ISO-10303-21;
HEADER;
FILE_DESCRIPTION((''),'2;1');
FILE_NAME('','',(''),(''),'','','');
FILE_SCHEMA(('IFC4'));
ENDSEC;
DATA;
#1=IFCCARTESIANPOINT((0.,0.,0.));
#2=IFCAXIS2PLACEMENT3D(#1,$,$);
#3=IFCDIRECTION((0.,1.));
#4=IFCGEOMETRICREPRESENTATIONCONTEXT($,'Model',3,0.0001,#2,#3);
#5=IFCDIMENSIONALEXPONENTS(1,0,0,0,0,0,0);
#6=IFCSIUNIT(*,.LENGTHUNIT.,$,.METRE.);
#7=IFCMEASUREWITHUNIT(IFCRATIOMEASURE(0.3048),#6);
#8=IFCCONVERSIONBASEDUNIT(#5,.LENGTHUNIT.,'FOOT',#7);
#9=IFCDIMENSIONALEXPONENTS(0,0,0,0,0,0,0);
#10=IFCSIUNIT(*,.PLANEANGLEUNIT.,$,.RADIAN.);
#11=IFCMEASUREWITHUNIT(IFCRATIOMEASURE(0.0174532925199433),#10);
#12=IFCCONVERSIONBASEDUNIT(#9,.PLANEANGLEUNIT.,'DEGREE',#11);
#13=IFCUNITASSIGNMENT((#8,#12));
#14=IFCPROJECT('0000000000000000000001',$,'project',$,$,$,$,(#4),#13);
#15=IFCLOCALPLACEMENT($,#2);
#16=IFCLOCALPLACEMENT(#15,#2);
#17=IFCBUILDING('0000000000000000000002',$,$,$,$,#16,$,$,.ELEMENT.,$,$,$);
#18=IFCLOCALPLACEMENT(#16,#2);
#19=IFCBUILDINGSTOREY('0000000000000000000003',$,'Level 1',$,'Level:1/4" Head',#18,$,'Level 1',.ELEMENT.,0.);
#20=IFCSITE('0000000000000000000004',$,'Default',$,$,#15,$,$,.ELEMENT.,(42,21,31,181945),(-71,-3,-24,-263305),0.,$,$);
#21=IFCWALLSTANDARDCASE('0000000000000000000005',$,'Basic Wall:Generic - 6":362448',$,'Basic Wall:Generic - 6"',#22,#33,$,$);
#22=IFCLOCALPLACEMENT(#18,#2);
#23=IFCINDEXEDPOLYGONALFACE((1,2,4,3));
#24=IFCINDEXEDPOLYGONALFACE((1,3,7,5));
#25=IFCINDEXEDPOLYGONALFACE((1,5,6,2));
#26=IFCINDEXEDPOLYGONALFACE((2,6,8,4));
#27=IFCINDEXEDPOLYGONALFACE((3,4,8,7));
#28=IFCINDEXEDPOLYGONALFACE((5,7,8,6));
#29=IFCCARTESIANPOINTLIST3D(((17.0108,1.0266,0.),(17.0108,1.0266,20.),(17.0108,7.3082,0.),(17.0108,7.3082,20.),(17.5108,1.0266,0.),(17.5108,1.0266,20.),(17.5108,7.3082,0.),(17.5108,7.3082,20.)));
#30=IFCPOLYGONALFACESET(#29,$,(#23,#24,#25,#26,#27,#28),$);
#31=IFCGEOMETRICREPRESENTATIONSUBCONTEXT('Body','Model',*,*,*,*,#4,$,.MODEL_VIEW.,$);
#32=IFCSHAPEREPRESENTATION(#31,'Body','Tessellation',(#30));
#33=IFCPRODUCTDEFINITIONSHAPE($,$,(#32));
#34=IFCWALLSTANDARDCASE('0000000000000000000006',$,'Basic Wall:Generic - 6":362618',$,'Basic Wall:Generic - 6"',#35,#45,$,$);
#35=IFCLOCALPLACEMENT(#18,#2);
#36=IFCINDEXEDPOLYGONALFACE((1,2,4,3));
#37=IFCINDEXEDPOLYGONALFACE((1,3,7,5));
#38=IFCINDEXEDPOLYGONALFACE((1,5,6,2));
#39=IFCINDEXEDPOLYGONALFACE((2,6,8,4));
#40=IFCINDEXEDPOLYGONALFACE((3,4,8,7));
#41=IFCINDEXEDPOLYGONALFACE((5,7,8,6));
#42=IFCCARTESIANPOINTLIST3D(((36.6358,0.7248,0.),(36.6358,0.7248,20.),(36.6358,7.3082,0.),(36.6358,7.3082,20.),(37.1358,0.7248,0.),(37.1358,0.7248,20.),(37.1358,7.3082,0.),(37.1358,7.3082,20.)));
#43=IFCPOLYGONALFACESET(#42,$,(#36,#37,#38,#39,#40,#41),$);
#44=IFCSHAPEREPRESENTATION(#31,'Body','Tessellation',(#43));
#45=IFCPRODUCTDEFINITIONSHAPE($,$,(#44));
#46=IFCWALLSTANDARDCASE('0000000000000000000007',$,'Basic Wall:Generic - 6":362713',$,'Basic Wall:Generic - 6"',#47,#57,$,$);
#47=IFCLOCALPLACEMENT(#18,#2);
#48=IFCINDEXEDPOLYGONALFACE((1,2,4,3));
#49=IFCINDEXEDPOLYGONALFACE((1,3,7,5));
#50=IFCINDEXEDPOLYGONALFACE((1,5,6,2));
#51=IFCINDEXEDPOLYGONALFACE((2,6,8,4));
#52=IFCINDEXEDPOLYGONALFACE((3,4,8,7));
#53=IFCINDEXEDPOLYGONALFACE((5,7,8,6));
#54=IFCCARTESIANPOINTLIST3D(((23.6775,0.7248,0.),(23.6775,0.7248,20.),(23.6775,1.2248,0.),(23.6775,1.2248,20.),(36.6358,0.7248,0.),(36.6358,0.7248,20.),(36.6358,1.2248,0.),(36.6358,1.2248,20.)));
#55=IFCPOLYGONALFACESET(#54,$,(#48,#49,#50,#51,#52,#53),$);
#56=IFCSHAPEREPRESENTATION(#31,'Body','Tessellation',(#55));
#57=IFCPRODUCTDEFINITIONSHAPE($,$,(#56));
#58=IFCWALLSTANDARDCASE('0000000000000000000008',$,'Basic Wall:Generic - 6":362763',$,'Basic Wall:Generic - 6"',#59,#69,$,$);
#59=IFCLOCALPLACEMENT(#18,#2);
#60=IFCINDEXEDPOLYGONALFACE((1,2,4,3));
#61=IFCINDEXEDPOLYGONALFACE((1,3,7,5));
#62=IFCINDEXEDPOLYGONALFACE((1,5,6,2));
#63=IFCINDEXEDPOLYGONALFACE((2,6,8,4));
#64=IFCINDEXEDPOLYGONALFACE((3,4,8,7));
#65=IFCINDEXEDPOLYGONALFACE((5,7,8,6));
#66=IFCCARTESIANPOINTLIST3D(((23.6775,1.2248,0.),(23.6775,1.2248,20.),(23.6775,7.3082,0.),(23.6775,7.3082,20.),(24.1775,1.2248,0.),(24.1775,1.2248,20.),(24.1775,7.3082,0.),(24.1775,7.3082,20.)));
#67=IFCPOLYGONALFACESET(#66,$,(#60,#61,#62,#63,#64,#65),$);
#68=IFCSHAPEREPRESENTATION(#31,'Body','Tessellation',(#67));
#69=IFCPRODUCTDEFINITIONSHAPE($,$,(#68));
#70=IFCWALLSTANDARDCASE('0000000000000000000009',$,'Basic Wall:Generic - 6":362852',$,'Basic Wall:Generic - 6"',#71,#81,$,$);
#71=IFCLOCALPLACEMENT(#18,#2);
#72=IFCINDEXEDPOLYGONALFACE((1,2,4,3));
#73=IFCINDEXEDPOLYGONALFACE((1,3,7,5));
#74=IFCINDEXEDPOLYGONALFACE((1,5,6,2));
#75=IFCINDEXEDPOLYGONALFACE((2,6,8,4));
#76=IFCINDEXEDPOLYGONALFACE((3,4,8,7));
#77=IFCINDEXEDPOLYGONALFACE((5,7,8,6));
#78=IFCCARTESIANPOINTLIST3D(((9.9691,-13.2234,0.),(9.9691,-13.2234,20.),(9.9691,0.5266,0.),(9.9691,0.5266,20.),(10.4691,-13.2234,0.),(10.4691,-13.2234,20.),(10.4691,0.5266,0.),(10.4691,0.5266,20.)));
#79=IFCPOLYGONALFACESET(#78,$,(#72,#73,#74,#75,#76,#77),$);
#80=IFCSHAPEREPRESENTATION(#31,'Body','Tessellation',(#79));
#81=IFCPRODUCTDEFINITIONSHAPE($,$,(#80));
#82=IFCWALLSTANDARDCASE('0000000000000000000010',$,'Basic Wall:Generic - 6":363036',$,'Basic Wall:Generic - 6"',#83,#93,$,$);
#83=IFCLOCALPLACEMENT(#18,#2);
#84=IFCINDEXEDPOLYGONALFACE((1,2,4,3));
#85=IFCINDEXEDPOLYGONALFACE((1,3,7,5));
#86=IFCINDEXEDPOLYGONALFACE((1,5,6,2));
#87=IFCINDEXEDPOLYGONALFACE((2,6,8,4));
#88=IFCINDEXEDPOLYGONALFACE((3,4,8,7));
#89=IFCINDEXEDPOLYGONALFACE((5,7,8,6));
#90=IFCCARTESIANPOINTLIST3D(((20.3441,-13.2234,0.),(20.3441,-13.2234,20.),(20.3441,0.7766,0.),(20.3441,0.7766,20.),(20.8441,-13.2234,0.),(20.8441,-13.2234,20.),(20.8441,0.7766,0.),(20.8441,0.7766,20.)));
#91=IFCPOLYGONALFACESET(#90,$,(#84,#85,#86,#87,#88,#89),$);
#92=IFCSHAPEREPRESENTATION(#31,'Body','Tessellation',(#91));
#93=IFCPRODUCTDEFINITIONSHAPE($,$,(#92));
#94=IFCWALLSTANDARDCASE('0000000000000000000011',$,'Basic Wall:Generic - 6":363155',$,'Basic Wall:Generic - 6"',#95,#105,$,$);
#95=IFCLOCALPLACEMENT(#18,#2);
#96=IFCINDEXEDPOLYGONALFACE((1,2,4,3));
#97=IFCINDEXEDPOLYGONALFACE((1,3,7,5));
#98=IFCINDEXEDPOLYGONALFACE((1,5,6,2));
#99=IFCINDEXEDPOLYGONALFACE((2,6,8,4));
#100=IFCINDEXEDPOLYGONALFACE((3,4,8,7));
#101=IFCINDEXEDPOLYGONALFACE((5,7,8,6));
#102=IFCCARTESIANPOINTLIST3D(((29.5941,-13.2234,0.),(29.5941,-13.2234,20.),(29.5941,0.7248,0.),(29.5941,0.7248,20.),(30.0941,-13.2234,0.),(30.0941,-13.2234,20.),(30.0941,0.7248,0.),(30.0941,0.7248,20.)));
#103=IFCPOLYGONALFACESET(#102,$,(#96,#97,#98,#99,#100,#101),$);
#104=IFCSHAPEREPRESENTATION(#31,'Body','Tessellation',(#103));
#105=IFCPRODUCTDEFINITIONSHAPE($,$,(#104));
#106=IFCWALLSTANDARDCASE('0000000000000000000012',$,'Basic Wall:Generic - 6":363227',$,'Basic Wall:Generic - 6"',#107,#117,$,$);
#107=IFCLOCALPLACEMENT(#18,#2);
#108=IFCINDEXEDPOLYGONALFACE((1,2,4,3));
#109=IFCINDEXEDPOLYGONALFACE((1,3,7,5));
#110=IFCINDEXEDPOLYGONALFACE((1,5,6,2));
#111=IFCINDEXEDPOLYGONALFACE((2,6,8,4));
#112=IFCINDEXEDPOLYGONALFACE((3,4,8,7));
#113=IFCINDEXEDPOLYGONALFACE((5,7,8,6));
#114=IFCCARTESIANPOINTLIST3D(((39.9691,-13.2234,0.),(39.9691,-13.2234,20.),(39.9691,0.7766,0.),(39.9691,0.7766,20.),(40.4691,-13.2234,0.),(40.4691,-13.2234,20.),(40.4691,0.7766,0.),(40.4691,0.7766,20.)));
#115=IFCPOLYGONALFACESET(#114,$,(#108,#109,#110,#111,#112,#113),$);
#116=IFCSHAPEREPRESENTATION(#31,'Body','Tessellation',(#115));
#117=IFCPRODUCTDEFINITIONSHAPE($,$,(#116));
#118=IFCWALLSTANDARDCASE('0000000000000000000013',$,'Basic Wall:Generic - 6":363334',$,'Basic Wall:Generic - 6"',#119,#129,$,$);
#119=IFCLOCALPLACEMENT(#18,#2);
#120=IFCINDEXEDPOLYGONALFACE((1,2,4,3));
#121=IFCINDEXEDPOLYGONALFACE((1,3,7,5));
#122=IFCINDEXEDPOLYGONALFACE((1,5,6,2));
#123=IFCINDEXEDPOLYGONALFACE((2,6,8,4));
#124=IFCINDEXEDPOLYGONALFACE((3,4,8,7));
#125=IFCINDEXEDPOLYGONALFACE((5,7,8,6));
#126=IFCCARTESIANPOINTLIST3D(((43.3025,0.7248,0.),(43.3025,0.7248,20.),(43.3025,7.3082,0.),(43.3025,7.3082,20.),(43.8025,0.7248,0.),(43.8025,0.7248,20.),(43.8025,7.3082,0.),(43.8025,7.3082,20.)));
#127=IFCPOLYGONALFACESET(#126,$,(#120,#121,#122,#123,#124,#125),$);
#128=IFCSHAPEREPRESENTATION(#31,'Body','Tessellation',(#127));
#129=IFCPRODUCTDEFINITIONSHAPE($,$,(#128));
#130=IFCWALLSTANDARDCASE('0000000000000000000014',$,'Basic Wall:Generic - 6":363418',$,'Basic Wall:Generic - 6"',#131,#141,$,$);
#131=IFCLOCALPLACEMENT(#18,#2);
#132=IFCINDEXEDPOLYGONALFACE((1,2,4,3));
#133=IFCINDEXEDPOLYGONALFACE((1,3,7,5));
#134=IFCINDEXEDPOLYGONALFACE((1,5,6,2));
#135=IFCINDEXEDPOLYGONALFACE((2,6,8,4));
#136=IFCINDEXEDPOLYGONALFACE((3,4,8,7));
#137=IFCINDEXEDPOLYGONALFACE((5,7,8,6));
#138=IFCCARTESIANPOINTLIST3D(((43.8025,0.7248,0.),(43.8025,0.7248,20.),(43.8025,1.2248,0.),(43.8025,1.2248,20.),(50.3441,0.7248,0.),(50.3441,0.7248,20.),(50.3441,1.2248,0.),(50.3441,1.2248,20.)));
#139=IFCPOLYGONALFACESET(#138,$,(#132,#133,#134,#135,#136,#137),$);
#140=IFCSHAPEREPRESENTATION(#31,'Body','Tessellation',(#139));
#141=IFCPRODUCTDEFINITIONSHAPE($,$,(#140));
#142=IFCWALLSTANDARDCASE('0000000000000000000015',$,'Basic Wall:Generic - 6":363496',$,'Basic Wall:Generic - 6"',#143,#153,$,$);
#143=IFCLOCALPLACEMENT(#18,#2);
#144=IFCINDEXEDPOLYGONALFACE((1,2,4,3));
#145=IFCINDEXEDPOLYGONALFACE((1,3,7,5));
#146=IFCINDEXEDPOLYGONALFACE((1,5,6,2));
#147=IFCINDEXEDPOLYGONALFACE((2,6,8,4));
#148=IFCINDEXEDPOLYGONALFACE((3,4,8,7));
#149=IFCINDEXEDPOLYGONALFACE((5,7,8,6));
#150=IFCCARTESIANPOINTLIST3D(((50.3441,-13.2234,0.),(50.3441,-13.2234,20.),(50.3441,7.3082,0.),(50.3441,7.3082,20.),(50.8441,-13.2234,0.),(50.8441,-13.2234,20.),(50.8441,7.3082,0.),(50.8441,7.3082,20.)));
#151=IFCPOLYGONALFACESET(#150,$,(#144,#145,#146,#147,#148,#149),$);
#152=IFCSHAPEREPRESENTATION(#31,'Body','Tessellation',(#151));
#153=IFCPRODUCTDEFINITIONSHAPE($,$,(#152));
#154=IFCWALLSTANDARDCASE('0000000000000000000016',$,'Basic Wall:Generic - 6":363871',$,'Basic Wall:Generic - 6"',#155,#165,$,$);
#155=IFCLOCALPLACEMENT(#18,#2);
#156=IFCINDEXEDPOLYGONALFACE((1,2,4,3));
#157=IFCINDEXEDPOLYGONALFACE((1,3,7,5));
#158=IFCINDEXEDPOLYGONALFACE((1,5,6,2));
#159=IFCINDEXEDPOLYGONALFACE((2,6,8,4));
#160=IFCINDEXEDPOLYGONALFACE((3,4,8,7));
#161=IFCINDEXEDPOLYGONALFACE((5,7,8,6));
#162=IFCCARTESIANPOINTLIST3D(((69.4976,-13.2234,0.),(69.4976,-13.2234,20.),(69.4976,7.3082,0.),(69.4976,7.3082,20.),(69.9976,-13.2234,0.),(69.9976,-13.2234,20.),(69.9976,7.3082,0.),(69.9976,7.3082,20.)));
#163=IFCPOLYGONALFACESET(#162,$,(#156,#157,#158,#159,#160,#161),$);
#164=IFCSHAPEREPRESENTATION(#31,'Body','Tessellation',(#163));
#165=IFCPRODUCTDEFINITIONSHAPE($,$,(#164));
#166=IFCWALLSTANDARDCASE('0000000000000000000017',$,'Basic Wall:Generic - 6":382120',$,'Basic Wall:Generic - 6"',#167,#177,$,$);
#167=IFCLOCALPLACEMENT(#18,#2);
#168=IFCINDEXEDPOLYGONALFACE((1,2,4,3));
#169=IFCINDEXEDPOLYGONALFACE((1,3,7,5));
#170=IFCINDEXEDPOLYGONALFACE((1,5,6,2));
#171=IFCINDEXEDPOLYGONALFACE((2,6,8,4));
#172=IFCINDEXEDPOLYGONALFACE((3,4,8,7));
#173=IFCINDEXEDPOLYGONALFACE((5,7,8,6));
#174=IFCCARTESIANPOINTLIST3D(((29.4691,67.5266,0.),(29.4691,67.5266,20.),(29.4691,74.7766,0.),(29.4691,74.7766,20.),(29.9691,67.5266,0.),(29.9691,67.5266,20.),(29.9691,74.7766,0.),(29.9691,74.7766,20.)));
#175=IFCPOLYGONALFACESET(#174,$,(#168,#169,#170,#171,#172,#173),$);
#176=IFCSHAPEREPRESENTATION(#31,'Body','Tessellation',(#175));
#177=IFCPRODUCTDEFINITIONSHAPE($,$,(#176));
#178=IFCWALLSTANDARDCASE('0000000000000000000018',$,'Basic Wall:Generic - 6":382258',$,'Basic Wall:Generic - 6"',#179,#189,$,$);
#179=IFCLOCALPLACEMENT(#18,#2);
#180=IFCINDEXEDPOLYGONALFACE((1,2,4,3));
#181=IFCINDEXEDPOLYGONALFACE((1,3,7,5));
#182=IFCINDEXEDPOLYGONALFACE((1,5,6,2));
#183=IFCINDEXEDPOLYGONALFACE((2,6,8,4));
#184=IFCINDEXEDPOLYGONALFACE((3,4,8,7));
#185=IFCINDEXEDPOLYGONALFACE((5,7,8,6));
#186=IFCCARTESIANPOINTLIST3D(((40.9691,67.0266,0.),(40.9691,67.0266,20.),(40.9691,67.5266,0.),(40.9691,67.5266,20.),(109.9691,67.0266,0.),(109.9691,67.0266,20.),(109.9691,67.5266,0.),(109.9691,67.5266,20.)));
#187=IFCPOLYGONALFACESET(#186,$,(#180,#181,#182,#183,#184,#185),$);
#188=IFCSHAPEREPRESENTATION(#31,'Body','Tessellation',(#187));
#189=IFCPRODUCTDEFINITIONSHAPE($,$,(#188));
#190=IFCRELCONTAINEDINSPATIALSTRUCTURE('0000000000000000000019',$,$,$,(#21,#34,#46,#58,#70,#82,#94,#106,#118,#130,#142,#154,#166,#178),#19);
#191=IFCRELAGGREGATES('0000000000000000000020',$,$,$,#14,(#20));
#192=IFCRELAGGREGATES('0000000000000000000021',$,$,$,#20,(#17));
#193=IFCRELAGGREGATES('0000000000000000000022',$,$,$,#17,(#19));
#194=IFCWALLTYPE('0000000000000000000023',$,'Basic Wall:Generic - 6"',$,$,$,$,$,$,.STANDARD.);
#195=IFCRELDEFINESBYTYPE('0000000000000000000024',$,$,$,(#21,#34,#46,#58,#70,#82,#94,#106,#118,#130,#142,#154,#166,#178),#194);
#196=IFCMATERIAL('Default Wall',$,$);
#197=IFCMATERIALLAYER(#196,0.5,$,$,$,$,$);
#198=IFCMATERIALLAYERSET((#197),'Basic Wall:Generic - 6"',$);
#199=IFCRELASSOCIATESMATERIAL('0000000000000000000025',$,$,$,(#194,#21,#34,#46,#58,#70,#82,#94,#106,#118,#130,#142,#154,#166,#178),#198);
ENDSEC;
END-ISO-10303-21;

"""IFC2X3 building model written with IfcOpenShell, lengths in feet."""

from ifc_helpers import new_model, entity, si_unit, converted_unit, direction, frame, frame_2d, origin, place, context, subcontext, project, spatial, rectangle, extrude, material, layer, layer_set, layer_usage, type_object, element, save


model = new_model("IFC2X3")

# Units and contexts
model_context = context("Model", 3, precision=0.0001, world=origin(), true_north=direction((0.0, 1.0)))
body_context = subcontext(model_context, "Body", "Model", "MODEL_VIEW")
ifc_project = project(units=[converted_unit("LENGTHUNIT", "FOOT", entity("IfcRatioMeasure", 0.3048), si_unit("LENGTHUNIT", "METRE"), dimensions=[1, 0, 0, 0, 0, 0, 0]), converted_unit("PLANEANGLEUNIT", "DEGREE", entity("IfcRatioMeasure", 0.0174532925199433), si_unit("PLANEANGLEUNIT", "RADIAN"), dimensions=[0, 0, 0, 0, 0, 0, 0])], contexts=[model_context])

# Site, building, storey
site_placement = place(None, origin())
site = spatial("IfcSite", under=ifc_project, at=site_placement, Name="Default", CompositionType="ELEMENT", RefLatitude=(42, 21, 31, 181945), RefLongitude=(-71, -3, -24, -263305), RefElevation=0.0)
building_placement = place(site_placement, origin())
building = spatial("IfcBuilding", under=site, at=building_placement, CompositionType="ELEMENT")
storey_placement = place(building_placement, origin())
storey = spatial("IfcBuildingStorey", under=building, at=storey_placement, Name="Level 1", ObjectType="Level:1/4\" Head", LongName="Level 1", CompositionType="ELEMENT", Elevation=0.0)

# Walls
ifc_material = material(Name="Default Wall")
ifc_layer = layer(ifc_material, 0.5)
ifc_layer_set = layer_set([ifc_layer], Name="Basic Wall:Generic - 6\"")
ifc_layer_usage_1 = layer_usage(ifc_layer_set, "AXIS2", "NEGATIVE", 0.25)
wall_type = type_object("IfcWallType", Name="Basic Wall:Generic - 6\"", PredefinedType="STANDARD", material=ifc_layer_set)
wall_1_placement = place(storey_placement, frame((17.2608, 1.0266, 0.0), z_axis=(0.0, 0.0, 1.0), x_axis=(0.0, 1.0, 0.0)))
element("IfcWallStandardCase", 1, at=wall_1_placement, inside=storey, type_object=wall_type, material=ifc_layer_usage_1, Name="Basic Wall:Generic - 6\":362448", ObjectType="Basic Wall:Generic - 6\"", context=body_context, shape_type="SweptSolid", body=[
    extrude(rectangle(XDim=6.2816, YDim=0.5, at=frame_2d((3.1408, 0.0), x_axis=(-1.0, 0.0))), origin(), (0.0, 0.0, 1.0), 20.0),
])
ifc_layer_usage_2 = layer_usage(ifc_layer_set, "AXIS2", "NEGATIVE", 0.25)
wall_2_placement = place(storey_placement, frame((36.8858, 7.3082, 0.0), z_axis=(0.0, 0.0, 1.0), x_axis=(0.0, -1.0, 0.0)))
element("IfcWallStandardCase", 2, at=wall_2_placement, inside=storey, type_object=wall_type, material=ifc_layer_usage_2, Name="Basic Wall:Generic - 6\":362618", ObjectType="Basic Wall:Generic - 6\"", context=body_context, shape_type="SweptSolid", body=[
    extrude(rectangle(XDim=6.5833, YDim=0.5, at=frame_2d((3.2917, 0.0), x_axis=(-1.0, 0.0))), origin(), (0.0, 0.0, 1.0), 20.0),
])
ifc_layer_usage_3 = layer_usage(ifc_layer_set, "AXIS2", "NEGATIVE", 0.25)
wall_3_placement = place(storey_placement, frame((36.6358, 0.9748, 0.0), z_axis=(0.0, 0.0, 1.0), x_axis=(-1.0, 0.0, 0.0)))
element("IfcWallStandardCase", 3, at=wall_3_placement, inside=storey, type_object=wall_type, material=ifc_layer_usage_3, Name="Basic Wall:Generic - 6\":362713", ObjectType="Basic Wall:Generic - 6\"", context=body_context, shape_type="SweptSolid", body=[
    extrude(rectangle(XDim=12.9583, YDim=0.5, at=frame_2d((6.4792, 0.0), x_axis=(-1.0, 0.0))), origin(), (0.0, 0.0, 1.0), 20.0),
])
ifc_layer_usage_4 = layer_usage(ifc_layer_set, "AXIS2", "NEGATIVE", 0.25)
wall_4_placement = place(storey_placement, frame((23.9275, 1.2248, 0.0), z_axis=(0.0, 0.0, 1.0), x_axis=(0.0, 1.0, 0.0)))
element("IfcWallStandardCase", 4, at=wall_4_placement, inside=storey, type_object=wall_type, material=ifc_layer_usage_4, Name="Basic Wall:Generic - 6\":362763", ObjectType="Basic Wall:Generic - 6\"", context=body_context, shape_type="SweptSolid", body=[
    extrude(rectangle(XDim=6.0833, YDim=0.5, at=frame_2d((3.0417, 0.0), x_axis=(-1.0, 0.0))), origin(), (0.0, 0.0, 1.0), 20.0),
])
ifc_layer_usage_5 = layer_usage(ifc_layer_set, "AXIS2", "NEGATIVE", 0.25)
wall_5_placement = place(storey_placement, frame((10.2191, 0.5266, 0.0), z_axis=(0.0, 0.0, 1.0), x_axis=(0.0, -1.0, 0.0)))
element("IfcWallStandardCase", 5, at=wall_5_placement, inside=storey, type_object=wall_type, material=ifc_layer_usage_5, Name="Basic Wall:Generic - 6\":362852", ObjectType="Basic Wall:Generic - 6\"", context=body_context, shape_type="SweptSolid", body=[
    extrude(rectangle(XDim=13.75, YDim=0.5, at=frame_2d((6.875, 0.0), x_axis=(-1.0, 0.0))), origin(), (0.0, 0.0, 1.0), 20.0),
])
ifc_layer_usage_6 = layer_usage(ifc_layer_set, "AXIS2", "NEGATIVE", 0.25)
wall_6_placement = place(storey_placement, frame((20.5941, -13.2234, 0.0), z_axis=(0.0, 0.0, 1.0), x_axis=(0.0, 1.0, 0.0)))
element("IfcWallStandardCase", 6, at=wall_6_placement, inside=storey, type_object=wall_type, material=ifc_layer_usage_6, Name="Basic Wall:Generic - 6\":363036", ObjectType="Basic Wall:Generic - 6\"", context=body_context, shape_type="SweptSolid", body=[
    extrude(rectangle(XDim=14.0, YDim=0.5, at=frame_2d((7.0, 0.0), x_axis=(-1.0, 0.0))), origin(), (0.0, 0.0, 1.0), 20.0),
])
ifc_layer_usage_7 = layer_usage(ifc_layer_set, "AXIS2", "NEGATIVE", 0.25)
wall_7_placement = place(storey_placement, frame((29.8441, -13.2234, 0.0), z_axis=(0.0, 0.0, 1.0), x_axis=(0.0, 1.0, 0.0)))
element("IfcWallStandardCase", 7, at=wall_7_placement, inside=storey, type_object=wall_type, material=ifc_layer_usage_7, Name="Basic Wall:Generic - 6\":363155", ObjectType="Basic Wall:Generic - 6\"", context=body_context, shape_type="SweptSolid", body=[
    extrude(rectangle(XDim=13.9482, YDim=0.5, at=frame_2d((6.9741, 0.0), x_axis=(-1.0, 0.0))), origin(), (0.0, 0.0, 1.0), 20.0),
])
ifc_layer_usage_8 = layer_usage(ifc_layer_set, "AXIS2", "NEGATIVE", 0.25)
wall_8_placement = place(storey_placement, frame((40.2191, -13.2234, 0.0), z_axis=(0.0, 0.0, 1.0), x_axis=(0.0, 1.0, 0.0)))
element("IfcWallStandardCase", 8, at=wall_8_placement, inside=storey, type_object=wall_type, material=ifc_layer_usage_8, Name="Basic Wall:Generic - 6\":363227", ObjectType="Basic Wall:Generic - 6\"", context=body_context, shape_type="SweptSolid", body=[
    extrude(rectangle(XDim=14.0, YDim=0.5, at=frame_2d((7.0, 0.0), x_axis=(-1.0, 0.0))), origin(), (0.0, 0.0, 1.0), 20.0),
])
ifc_layer_usage_9 = layer_usage(ifc_layer_set, "AXIS2", "NEGATIVE", 0.25)
wall_9_placement = place(storey_placement, frame((43.5525, 7.3082, 0.0), z_axis=(0.0, 0.0, 1.0), x_axis=(0.0, -1.0, 0.0)))
element("IfcWallStandardCase", 9, at=wall_9_placement, inside=storey, type_object=wall_type, material=ifc_layer_usage_9, Name="Basic Wall:Generic - 6\":363334", ObjectType="Basic Wall:Generic - 6\"", context=body_context, shape_type="SweptSolid", body=[
    extrude(rectangle(XDim=6.5833, YDim=0.5, at=frame_2d((3.2917, 0.0), x_axis=(-1.0, 0.0))), origin(), (0.0, 0.0, 1.0), 20.0),
])
ifc_layer_usage_10 = layer_usage(ifc_layer_set, "AXIS2", "NEGATIVE", 0.25)
wall_10_placement = place(storey_placement, frame((43.8025, 0.9748, 0.0)))
element("IfcWallStandardCase", 10, at=wall_10_placement, inside=storey, type_object=wall_type, material=ifc_layer_usage_10, Name="Basic Wall:Generic - 6\":363418", ObjectType="Basic Wall:Generic - 6\"", context=body_context, shape_type="SweptSolid", body=[
    extrude(rectangle(XDim=6.5417, YDim=0.5, at=frame_2d((3.2708, 0.0), x_axis=(-1.0, 0.0))), origin(), (0.0, 0.0, 1.0), 20.0),
])
ifc_layer_usage_11 = layer_usage(ifc_layer_set, "AXIS2", "NEGATIVE", 0.25)
wall_11_placement = place(storey_placement, frame((50.5941, 7.3082, 0.0), z_axis=(0.0, 0.0, 1.0), x_axis=(0.0, -1.0, 0.0)))
element("IfcWallStandardCase", 11, at=wall_11_placement, inside=storey, type_object=wall_type, material=ifc_layer_usage_11, Name="Basic Wall:Generic - 6\":363496", ObjectType="Basic Wall:Generic - 6\"", context=body_context, shape_type="SweptSolid", body=[
    extrude(rectangle(XDim=20.5316, YDim=0.5, at=frame_2d((10.2658, 0.0), x_axis=(-1.0, 0.0))), origin(), (0.0, 0.0, 1.0), 20.0),
])
ifc_layer_usage_12 = layer_usage(ifc_layer_set, "AXIS2", "NEGATIVE", 0.25)
wall_12_placement = place(storey_placement, frame((69.7476, 7.3082, 0.0), z_axis=(0.0, 0.0, 1.0), x_axis=(0.0, -1.0, 0.0)))
element("IfcWallStandardCase", 12, at=wall_12_placement, inside=storey, type_object=wall_type, material=ifc_layer_usage_12, Name="Basic Wall:Generic - 6\":363871", ObjectType="Basic Wall:Generic - 6\"", context=body_context, shape_type="SweptSolid", body=[
    extrude(rectangle(XDim=20.5316, YDim=0.5, at=frame_2d((10.2658, 0.0), x_axis=(-1.0, 0.0))), origin(), (0.0, 0.0, 1.0), 20.0),
])
ifc_layer_usage_13 = layer_usage(ifc_layer_set, "AXIS2", "NEGATIVE", 0.25)
wall_13_placement = place(storey_placement, frame((29.7191, 67.5266, 0.0), z_axis=(0.0, 0.0, 1.0), x_axis=(0.0, 1.0, 0.0)))
element("IfcWallStandardCase", 13, at=wall_13_placement, inside=storey, type_object=wall_type, material=ifc_layer_usage_13, Name="Basic Wall:Generic - 6\":382120", ObjectType="Basic Wall:Generic - 6\"", context=body_context, shape_type="SweptSolid", body=[
    extrude(rectangle(XDim=7.25, YDim=0.5, at=frame_2d((3.625, 0.0), x_axis=(-1.0, 0.0))), origin(), (0.0, 0.0, 1.0), 20.0),
])
ifc_layer_usage_14 = layer_usage(ifc_layer_set, "AXIS2", "NEGATIVE", 0.25)
wall_14_placement = place(storey_placement, frame((40.9691, 67.2766, 0.0)))
element("IfcWallStandardCase", 14, at=wall_14_placement, inside=storey, type_object=wall_type, material=ifc_layer_usage_14, Name="Basic Wall:Generic - 6\":382258", ObjectType="Basic Wall:Generic - 6\"", context=body_context, shape_type="SweptSolid", body=[
    extrude(rectangle(XDim=69.0, YDim=0.5, at=frame_2d((34.5, 0.0), x_axis=(-1.0, 0.0))), origin(), (0.0, 0.0, 1.0), 20.0),
])

save(model, "model.ifc")
